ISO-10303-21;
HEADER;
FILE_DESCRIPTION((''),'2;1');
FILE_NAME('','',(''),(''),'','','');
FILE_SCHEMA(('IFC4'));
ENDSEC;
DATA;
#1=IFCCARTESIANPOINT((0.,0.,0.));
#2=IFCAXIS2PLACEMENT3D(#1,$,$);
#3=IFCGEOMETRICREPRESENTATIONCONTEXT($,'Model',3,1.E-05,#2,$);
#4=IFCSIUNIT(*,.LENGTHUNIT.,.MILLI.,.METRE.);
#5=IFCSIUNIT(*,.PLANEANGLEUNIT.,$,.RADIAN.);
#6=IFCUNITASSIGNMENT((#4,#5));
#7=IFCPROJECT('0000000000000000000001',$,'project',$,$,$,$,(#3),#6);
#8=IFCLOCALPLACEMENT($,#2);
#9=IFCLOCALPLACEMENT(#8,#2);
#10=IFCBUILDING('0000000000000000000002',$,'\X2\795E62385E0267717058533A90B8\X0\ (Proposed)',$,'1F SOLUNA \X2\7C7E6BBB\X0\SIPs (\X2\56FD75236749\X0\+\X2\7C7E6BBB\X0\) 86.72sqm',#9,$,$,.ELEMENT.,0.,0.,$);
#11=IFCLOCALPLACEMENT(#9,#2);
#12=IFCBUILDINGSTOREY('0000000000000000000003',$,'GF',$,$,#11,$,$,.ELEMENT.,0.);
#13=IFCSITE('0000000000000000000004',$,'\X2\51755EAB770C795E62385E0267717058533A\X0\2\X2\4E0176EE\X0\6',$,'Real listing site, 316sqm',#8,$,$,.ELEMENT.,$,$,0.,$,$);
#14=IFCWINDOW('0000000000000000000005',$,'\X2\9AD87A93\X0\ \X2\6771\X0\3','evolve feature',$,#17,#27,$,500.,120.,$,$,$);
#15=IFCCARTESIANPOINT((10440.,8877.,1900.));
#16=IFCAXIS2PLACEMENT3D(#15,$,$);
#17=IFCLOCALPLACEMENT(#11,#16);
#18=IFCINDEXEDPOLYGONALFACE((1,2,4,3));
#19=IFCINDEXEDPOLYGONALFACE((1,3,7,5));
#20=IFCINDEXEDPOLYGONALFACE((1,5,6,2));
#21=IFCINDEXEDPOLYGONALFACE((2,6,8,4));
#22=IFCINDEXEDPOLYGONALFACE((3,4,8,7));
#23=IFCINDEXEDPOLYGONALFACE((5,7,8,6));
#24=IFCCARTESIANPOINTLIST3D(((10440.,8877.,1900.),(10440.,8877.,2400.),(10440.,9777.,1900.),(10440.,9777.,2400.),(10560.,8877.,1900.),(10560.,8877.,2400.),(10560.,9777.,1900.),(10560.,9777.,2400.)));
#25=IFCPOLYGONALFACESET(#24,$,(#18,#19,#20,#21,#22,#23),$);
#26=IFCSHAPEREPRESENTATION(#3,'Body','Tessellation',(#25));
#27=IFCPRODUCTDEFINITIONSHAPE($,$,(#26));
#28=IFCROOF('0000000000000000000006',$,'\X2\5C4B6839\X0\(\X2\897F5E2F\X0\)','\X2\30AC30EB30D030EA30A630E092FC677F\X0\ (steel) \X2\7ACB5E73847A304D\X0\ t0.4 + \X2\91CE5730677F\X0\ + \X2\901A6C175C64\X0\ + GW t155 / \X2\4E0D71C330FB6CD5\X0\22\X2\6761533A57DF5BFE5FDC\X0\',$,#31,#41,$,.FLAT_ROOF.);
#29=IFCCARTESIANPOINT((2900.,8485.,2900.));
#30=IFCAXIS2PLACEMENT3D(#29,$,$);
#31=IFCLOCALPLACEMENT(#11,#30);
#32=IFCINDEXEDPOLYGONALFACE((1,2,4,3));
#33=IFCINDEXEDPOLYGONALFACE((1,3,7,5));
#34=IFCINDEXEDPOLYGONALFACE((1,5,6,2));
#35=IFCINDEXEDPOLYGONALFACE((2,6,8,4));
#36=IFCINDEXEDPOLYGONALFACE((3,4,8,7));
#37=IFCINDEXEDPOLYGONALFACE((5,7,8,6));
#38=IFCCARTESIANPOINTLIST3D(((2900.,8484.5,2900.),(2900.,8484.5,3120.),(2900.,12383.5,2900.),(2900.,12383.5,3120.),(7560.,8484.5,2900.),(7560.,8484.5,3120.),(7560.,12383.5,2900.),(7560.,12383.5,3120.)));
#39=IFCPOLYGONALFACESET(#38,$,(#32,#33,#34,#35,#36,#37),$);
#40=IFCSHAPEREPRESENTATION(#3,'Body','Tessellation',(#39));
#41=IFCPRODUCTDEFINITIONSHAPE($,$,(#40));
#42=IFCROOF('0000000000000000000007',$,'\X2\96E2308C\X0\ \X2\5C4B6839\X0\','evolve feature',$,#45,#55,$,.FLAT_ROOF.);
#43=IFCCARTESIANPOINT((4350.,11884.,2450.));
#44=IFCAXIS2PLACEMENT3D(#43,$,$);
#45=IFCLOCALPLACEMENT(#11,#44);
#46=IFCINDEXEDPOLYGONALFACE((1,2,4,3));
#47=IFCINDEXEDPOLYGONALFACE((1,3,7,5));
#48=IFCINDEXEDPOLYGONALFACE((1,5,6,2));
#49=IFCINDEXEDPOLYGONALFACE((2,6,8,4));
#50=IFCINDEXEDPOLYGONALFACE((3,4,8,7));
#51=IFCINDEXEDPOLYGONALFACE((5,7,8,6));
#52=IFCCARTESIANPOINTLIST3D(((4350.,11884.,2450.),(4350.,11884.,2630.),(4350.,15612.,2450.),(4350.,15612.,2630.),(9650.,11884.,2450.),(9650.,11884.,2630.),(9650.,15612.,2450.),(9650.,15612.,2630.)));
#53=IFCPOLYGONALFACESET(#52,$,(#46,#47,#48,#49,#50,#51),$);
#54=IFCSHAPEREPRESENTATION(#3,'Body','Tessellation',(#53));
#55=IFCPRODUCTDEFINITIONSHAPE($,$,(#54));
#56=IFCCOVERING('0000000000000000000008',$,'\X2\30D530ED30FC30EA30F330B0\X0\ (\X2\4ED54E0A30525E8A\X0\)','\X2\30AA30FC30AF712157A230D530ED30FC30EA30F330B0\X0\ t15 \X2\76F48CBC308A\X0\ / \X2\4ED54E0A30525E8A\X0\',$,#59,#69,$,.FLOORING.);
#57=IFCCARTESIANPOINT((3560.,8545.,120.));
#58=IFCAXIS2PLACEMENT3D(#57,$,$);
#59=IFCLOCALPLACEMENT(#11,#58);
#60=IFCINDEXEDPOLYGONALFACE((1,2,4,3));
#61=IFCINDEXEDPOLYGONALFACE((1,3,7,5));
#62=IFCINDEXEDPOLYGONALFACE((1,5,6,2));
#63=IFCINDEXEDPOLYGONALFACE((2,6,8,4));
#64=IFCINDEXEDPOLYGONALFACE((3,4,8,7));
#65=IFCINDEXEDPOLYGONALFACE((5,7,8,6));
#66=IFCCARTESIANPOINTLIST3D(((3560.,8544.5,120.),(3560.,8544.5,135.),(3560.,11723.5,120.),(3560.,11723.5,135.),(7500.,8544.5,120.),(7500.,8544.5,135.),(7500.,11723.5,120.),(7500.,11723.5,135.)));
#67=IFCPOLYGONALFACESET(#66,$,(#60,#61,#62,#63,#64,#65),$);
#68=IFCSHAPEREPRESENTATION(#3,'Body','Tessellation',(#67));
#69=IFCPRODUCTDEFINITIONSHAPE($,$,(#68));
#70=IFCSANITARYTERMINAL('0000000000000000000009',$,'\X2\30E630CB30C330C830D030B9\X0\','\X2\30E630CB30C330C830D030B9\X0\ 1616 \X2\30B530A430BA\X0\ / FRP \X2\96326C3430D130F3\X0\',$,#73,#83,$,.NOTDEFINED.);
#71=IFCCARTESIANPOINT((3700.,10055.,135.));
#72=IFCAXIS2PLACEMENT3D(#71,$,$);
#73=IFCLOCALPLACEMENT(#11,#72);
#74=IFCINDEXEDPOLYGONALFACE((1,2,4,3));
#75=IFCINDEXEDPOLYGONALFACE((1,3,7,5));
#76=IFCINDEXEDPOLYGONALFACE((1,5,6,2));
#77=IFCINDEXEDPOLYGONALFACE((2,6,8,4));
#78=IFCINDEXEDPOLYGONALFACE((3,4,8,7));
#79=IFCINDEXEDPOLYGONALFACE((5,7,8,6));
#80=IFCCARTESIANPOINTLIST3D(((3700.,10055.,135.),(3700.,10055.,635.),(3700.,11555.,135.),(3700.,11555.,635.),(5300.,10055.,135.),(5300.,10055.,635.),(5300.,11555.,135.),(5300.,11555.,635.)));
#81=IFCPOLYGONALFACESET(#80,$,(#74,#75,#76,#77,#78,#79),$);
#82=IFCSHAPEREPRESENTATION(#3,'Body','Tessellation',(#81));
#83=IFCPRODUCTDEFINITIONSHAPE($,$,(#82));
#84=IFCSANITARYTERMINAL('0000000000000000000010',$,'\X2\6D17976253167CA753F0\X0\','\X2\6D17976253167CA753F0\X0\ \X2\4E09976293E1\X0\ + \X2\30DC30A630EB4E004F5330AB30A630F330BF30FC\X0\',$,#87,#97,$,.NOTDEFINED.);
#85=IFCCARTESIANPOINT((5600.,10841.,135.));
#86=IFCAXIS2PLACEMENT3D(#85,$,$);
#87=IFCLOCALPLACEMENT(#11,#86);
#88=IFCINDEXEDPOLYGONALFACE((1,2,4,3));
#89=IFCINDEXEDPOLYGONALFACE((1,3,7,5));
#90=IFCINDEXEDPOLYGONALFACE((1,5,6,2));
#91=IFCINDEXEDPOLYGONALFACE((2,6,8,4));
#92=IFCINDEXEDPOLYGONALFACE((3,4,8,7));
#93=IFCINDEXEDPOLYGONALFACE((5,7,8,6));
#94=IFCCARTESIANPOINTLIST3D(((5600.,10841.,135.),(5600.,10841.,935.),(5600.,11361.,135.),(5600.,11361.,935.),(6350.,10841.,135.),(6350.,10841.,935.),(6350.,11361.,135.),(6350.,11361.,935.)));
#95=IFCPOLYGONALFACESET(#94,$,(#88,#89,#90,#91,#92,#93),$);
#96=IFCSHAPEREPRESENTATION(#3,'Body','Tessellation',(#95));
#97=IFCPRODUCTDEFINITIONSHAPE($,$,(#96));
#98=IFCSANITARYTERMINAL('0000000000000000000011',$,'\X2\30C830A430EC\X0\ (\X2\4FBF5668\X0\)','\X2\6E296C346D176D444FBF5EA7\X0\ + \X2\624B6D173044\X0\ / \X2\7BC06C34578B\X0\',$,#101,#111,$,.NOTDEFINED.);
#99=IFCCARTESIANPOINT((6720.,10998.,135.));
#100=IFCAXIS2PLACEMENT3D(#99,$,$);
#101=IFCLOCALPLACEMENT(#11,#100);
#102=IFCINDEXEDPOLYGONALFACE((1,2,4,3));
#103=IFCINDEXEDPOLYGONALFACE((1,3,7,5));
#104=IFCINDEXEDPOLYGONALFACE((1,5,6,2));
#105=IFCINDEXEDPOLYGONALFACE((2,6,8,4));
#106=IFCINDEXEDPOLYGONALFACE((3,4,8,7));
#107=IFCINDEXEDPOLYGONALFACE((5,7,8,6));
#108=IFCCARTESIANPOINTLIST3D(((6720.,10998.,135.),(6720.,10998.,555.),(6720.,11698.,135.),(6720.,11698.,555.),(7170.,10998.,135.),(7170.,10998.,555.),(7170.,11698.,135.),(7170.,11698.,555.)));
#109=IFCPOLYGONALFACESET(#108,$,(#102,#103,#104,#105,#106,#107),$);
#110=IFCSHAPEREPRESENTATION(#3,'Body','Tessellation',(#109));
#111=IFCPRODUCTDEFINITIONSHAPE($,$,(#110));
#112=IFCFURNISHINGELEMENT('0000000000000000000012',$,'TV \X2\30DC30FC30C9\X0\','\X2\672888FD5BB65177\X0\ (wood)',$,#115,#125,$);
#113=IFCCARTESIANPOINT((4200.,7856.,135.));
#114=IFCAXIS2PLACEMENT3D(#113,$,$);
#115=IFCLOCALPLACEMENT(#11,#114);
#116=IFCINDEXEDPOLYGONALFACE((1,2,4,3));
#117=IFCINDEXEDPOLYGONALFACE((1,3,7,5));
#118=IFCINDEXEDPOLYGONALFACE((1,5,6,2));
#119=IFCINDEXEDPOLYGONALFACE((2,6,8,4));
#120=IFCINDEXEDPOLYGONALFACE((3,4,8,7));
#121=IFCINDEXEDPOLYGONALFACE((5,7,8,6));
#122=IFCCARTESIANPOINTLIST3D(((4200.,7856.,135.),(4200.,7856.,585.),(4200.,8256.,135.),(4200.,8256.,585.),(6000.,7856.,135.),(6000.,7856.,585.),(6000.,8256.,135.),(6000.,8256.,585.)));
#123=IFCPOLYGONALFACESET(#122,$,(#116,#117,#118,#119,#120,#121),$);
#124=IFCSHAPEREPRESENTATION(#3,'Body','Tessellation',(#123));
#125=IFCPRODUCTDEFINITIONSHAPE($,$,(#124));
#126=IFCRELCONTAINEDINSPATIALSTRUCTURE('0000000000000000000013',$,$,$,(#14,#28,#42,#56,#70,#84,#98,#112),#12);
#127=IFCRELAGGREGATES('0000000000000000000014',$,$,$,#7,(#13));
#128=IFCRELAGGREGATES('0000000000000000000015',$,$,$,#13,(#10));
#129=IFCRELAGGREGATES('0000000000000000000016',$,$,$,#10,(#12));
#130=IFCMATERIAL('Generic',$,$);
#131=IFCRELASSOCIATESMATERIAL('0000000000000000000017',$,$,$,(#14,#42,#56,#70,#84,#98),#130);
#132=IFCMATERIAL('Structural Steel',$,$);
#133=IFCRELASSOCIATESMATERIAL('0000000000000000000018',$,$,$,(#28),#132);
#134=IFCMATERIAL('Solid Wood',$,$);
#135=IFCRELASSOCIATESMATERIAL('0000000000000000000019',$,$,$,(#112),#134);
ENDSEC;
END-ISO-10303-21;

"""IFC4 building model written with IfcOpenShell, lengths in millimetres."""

from ifc_helpers import new_model, si_unit, frame, frame_2d, origin, place, context, project, spatial, rectangle, extrude, material, element, save


model = new_model("IFC4")

# Units and contexts
model_context = context("Model", 3, precision=1e-05, world=origin())
ifc_project = project(units=[si_unit("LENGTHUNIT", "METRE", prefix="MILLI"), si_unit("PLANEANGLEUNIT", "RADIAN")], contexts=[model_context])

# Site, building, storey
site_placement = place(None, origin())
site = spatial("IfcSite", under=ifc_project, at=site_placement, Name="兵庫県神戸市東灘区2丁目6", ObjectType="Real listing site, 316sqm", CompositionType="ELEMENT", RefElevation=0.0)
building_placement = place(site_placement, origin())
building = spatial("IfcBuilding", under=site, at=building_placement, Name="神戸市東灘区邸 (Proposed)", ObjectType="1F SOLUNA 籾殻SIPs (国産杉+籾殻) 86.72sqm", CompositionType="ELEMENT", ElevationOfRefHeight=0.0, ElevationOfTerrain=0.0)
storey_placement = place(building_placement, origin())
storey = spatial("IfcBuildingStorey", under=building, at=storey_placement, Name="GF", CompositionType="ELEMENT", Elevation=0.0)

# Shared definitions
ifc_material_1 = material(Name="Solid Wood")
ifc_material_2 = material(Name="Generic")

# Window
window_1_placement = place(storey_placement, frame((10440.0, 8877.0, 1900.0)))
element("IfcWindow", 1, at=window_1_placement, inside=storey, material=ifc_material_2, Name="高窓 東3", Description="evolve feature", OverallHeight=500.0, OverallWidth=120.0, context=model_context, shape_type="SweptSolid", body=[
    extrude(rectangle(XDim=120.0, YDim=900.0, at=frame_2d((60.0, 450.0))), frame((10440.0, 8877.0, 1900.0)), (0.0, 0.0, 1.0), 500.0),
])

# Roofs
ifc_material_3 = material(Name="Structural Steel")
roof_1_placement = place(storey_placement, frame((2900.0, 8485.0, 2900.0)))
element("IfcRoof", 2, at=roof_1_placement, inside=storey, material=ifc_material_3, Name="屋根(西帯)", Description="ガルバリウム鋼板 (steel) 立平葺き t0.4 + 野地板 + 通気層 + GW t155 / 不燃・法22条区域対応", PredefinedType="FLAT_ROOF", context=model_context, shape_type="SweptSolid", body=[
    extrude(rectangle(XDim=4660.0, YDim=3899.0, at=frame_2d((2330.0, 1949.0))), frame((2900.0, 8485.0, 2900.0)), (0.0, 0.0, 1.0), 220.0),
])
roof_2_placement = place(storey_placement, frame((4350.0, 11884.0, 2450.0)))
element("IfcRoof", 3, at=roof_2_placement, inside=storey, material=ifc_material_2, Name="離れ 屋根", Description="evolve feature", PredefinedType="FLAT_ROOF", context=model_context, shape_type="SweptSolid", body=[
    extrude(rectangle(XDim=5300.0, YDim=3728.0, at=frame_2d((2650.0, 1864.0))), frame((4350.0, 11884.0, 2450.0)), (0.0, 0.0, 1.0), 180.0),
])

# Covering
covering_placement = place(storey_placement, frame((3560.0, 8545.0, 120.0)))
element("IfcCovering", 4, at=covering_placement, inside=storey, material=ifc_material_2, Name="フローリング (仕上げ床)", Description="オーク無垢フローリング t15 直貼り / 仕上げ床", PredefinedType="FLOORING", context=model_context, shape_type="SweptSolid", body=[
    extrude(rectangle(XDim=3940.0, YDim=3179.0, at=frame_2d((1970.0, 1589.0))), frame((3560.0, 8545.0, 120.0)), (0.0, 0.0, 1.0), 15.0),
])

# Sanitary terminals
sanitary_terminal_1_placement = place(storey_placement, frame((3700.0, 10055.0, 135.0)))
element("IfcSanitaryTerminal", 5, at=sanitary_terminal_1_placement, inside=storey, material=ifc_material_2, Name="ユニットバス", Description="ユニットバス 1616 サイズ / FRP 防水パン", PredefinedType="NOTDEFINED", context=model_context, shape_type="SweptSolid", body=[
    extrude(rectangle(XDim=1600.0, YDim=1500.0, at=frame_2d((800.0, 750.0))), frame((3700.0, 10055.0, 135.0)), (0.0, 0.0, 1.0), 500.0),
])
sanitary_terminal_2_placement = place(storey_placement, frame((5600.0, 10841.0, 135.0)))
element("IfcSanitaryTerminal", 6, at=sanitary_terminal_2_placement, inside=storey, material=ifc_material_2, Name="洗面化粧台", Description="洗面化粧台 三面鏡 + ボウル一体カウンター", PredefinedType="NOTDEFINED", context=model_context, shape_type="SweptSolid", body=[
    extrude(rectangle(XDim=750.0, YDim=520.0, at=frame_2d((375.0, 260.0))), frame((5600.0, 10841.0, 135.0)), (0.0, 0.0, 1.0), 800.0),
])
sanitary_terminal_3_placement = place(storey_placement, frame((6720.0, 10998.0, 135.0)))
element("IfcSanitaryTerminal", 7, at=sanitary_terminal_3_placement, inside=storey, material=ifc_material_2, Name="トイレ (便器)", Description="温水洗浄便座 + 手洗い / 節水型", PredefinedType="NOTDEFINED", context=model_context, shape_type="SweptSolid", body=[
    extrude(rectangle(XDim=450.0, YDim=700.0, at=frame_2d((225.0, 350.0))), frame((6720.0, 10998.0, 135.0)), (0.0, 0.0, 1.0), 420.0),
])

# Furnishing element
furnishing_placement = place(storey_placement, frame((4200.0, 7856.0, 135.0)))
element("IfcFurnishingElement", 8, at=furnishing_placement, inside=storey, material=ifc_material_1, Name="TV ボード", Description="木製家具 (wood)", context=model_context, shape_type="SweptSolid", body=[
    extrude(rectangle(XDim=1800.0, YDim=400.0, at=frame_2d((900.0, 200.0))), frame((4200.0, 7856.0, 135.0)), (0.0, 0.0, 1.0), 450.0),
])

save(model, "model.ifc")
